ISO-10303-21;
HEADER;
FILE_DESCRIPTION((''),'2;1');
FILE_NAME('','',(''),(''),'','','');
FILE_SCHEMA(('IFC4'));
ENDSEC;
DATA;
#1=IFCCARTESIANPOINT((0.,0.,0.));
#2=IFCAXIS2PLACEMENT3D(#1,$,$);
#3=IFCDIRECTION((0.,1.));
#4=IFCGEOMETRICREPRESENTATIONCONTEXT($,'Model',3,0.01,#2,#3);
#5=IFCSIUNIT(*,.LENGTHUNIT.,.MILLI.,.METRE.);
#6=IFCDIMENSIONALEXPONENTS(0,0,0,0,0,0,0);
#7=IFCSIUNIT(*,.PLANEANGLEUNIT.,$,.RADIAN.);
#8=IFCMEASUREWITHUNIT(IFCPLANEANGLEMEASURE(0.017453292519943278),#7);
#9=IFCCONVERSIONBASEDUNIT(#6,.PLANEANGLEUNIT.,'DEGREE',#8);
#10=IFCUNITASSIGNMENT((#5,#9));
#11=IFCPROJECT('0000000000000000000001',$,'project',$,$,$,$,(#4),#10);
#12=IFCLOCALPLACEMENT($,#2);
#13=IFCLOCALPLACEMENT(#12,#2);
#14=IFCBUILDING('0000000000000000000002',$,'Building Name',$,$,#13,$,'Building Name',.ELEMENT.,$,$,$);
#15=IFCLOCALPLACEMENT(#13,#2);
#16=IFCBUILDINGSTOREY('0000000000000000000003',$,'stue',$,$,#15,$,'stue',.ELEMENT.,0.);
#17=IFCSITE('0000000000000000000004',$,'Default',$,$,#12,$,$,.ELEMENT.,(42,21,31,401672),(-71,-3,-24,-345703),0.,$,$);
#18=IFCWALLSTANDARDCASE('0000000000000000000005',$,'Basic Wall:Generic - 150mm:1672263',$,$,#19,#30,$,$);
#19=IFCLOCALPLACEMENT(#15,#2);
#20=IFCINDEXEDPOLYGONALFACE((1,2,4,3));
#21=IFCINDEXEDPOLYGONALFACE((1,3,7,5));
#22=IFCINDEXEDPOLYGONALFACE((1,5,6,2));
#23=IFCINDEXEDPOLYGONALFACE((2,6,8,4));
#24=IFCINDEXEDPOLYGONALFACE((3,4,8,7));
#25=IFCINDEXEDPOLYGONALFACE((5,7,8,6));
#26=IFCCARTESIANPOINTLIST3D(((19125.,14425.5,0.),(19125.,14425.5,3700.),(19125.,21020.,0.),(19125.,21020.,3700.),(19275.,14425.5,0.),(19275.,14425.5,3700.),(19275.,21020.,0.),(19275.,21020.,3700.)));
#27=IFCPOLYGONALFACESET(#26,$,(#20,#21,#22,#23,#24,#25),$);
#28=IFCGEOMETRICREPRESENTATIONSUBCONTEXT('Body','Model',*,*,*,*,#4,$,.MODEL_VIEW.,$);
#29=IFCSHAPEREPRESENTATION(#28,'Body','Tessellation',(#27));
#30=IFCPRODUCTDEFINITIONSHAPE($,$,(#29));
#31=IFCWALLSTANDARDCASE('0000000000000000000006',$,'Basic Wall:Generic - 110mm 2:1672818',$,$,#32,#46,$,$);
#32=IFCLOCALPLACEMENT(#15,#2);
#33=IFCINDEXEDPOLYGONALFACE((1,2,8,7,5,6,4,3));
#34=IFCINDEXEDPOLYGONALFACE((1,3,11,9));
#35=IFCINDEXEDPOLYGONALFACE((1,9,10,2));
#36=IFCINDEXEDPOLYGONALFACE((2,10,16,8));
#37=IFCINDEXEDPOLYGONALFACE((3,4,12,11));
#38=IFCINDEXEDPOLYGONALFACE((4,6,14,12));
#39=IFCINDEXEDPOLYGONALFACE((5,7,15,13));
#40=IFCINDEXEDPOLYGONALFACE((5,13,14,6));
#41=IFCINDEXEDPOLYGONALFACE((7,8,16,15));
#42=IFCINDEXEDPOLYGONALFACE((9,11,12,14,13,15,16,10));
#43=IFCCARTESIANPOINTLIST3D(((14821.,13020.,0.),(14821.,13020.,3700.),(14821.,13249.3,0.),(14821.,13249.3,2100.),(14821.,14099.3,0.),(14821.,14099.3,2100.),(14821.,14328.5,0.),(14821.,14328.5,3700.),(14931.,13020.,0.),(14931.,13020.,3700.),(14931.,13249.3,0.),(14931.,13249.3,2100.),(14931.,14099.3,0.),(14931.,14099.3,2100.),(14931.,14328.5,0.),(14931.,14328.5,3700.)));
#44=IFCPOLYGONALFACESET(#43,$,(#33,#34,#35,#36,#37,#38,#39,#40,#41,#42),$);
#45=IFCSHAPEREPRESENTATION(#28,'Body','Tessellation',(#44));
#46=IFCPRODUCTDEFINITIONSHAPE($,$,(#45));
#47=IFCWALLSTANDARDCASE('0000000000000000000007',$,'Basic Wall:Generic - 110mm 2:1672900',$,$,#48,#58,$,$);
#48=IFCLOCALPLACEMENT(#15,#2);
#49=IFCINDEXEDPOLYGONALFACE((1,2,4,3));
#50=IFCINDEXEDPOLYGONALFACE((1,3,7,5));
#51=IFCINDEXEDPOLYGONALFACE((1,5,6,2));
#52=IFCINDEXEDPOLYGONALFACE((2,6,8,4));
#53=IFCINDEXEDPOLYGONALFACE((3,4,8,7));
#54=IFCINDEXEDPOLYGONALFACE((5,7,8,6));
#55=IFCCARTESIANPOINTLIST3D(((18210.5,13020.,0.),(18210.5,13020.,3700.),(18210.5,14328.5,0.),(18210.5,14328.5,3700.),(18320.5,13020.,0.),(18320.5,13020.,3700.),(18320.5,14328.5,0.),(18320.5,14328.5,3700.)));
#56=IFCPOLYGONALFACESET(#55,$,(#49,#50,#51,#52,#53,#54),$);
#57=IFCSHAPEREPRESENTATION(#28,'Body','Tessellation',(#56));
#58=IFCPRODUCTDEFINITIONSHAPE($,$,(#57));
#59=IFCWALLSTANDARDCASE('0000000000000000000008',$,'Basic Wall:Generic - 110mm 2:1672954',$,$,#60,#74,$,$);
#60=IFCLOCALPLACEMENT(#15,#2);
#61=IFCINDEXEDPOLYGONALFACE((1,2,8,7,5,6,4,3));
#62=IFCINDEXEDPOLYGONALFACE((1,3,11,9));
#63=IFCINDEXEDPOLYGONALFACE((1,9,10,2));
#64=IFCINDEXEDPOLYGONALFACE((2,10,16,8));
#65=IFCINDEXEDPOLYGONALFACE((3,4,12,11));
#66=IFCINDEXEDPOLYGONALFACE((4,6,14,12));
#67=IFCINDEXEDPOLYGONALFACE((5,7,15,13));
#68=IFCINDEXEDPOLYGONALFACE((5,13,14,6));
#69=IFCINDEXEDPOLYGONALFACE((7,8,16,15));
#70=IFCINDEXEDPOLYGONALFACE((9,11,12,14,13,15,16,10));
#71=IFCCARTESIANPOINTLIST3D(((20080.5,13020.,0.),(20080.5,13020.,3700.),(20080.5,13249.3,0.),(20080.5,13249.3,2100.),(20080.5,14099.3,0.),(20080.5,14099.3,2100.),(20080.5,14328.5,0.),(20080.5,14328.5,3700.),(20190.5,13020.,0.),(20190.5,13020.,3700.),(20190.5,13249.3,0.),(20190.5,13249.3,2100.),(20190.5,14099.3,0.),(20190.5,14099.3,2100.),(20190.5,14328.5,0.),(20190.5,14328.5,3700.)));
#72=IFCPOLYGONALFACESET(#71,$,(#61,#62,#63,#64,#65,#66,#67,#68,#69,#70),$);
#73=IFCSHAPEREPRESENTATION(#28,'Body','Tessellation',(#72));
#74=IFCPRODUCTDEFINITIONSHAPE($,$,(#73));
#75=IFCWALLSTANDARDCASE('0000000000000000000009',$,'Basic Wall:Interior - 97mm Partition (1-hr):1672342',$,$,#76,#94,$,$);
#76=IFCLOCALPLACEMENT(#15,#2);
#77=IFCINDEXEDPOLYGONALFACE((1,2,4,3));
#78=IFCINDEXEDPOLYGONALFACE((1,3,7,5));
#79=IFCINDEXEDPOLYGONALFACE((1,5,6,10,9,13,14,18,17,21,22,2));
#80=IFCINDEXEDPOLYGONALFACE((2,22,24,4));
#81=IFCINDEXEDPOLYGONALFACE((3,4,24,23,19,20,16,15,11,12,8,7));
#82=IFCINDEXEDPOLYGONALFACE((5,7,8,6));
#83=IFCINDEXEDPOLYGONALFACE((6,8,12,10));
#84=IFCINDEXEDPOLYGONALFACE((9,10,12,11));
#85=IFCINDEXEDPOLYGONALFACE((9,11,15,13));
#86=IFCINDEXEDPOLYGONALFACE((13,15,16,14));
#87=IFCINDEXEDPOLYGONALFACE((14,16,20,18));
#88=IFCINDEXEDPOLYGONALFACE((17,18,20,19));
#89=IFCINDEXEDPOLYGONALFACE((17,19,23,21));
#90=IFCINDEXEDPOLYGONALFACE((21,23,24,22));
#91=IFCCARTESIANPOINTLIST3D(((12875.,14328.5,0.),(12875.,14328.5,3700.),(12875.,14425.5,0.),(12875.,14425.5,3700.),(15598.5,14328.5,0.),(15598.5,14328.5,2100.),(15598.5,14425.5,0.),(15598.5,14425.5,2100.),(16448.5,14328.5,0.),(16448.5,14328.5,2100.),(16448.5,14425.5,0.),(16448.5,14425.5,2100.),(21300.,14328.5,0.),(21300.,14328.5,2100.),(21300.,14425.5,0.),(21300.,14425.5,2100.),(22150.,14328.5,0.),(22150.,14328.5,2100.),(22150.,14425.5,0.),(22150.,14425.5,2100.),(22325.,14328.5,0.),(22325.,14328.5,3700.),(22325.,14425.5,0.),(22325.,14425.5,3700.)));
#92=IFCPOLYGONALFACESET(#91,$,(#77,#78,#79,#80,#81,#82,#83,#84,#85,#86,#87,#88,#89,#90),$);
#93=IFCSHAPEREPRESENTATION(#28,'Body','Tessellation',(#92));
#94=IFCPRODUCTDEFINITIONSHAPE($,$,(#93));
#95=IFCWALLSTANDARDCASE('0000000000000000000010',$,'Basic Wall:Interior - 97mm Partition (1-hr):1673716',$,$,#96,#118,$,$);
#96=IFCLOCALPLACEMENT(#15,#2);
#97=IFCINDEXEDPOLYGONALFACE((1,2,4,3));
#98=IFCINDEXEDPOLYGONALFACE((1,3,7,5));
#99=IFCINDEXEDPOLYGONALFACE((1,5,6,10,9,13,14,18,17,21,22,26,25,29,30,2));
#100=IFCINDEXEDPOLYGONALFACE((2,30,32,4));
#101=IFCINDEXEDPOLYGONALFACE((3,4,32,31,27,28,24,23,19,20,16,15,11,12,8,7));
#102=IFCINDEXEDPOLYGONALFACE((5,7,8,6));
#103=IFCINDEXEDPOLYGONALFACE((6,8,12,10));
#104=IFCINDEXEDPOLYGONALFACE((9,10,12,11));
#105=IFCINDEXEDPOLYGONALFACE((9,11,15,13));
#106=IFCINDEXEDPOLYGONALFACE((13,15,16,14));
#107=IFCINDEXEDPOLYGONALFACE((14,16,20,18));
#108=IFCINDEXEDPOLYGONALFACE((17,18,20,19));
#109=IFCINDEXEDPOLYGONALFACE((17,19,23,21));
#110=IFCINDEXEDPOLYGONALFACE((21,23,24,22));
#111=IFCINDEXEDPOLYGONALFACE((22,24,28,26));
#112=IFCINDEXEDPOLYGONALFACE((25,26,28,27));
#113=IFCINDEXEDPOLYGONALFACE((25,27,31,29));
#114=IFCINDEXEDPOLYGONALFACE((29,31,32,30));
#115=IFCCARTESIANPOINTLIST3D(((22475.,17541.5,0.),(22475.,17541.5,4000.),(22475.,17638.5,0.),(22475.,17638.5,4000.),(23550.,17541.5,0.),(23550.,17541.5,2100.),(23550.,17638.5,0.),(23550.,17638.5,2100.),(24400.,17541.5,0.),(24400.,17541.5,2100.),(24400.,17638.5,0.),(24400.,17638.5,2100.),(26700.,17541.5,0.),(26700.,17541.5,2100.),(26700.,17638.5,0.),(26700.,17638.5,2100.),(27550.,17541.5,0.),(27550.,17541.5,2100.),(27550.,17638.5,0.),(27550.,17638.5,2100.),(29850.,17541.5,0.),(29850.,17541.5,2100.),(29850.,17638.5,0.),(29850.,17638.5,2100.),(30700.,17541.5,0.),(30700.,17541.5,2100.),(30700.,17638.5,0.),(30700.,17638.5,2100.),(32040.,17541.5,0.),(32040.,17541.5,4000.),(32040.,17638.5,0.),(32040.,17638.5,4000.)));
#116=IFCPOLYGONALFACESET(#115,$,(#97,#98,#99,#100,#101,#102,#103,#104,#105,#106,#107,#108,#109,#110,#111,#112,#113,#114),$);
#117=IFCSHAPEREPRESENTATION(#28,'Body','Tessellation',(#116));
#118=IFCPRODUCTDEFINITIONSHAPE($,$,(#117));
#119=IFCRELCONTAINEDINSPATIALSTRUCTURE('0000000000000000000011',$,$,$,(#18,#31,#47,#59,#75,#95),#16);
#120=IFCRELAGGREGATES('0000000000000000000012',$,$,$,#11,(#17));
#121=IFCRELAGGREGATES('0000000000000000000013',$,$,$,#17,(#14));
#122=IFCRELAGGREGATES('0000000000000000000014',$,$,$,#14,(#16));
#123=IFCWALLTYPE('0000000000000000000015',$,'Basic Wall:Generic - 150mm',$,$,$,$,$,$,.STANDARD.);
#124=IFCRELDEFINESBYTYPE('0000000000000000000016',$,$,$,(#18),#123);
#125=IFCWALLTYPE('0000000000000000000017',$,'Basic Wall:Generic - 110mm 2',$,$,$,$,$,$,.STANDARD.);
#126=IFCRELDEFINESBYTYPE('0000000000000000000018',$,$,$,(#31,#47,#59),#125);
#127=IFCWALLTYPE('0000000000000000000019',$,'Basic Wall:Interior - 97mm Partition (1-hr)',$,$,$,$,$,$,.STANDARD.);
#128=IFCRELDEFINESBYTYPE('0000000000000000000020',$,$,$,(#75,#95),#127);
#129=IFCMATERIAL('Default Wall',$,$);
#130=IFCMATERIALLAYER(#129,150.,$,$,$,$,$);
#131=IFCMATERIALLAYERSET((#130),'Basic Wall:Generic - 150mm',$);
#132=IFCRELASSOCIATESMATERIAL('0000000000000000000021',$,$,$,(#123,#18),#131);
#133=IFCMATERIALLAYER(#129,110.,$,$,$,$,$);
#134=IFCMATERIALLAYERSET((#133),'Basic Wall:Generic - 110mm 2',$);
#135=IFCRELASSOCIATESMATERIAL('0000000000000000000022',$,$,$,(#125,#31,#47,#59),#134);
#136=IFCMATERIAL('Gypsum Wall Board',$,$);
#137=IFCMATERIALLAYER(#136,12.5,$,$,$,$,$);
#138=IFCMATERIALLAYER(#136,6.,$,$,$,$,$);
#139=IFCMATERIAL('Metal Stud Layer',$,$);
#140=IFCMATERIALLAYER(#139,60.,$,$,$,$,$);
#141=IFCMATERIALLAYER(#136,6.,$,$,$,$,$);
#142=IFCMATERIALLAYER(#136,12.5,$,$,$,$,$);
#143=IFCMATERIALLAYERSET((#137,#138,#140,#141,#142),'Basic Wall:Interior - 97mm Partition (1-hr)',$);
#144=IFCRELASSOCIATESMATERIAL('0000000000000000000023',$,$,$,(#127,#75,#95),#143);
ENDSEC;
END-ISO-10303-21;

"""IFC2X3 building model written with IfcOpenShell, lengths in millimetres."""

from ifc_helpers import new_model, entity, si_unit, converted_unit, direction, frame, frame_2d, origin, place, context, subcontext, project, spatial, polyline, rectangle, extrude, clip, bounded_halfspace, material, layer, layer_set, layer_usage, type_object, element, save


model = new_model("IFC2X3")

# Units and contexts
model_context = context("Model", 3, precision=0.01, world=origin(), true_north=direction((0.0, 1.0)))
body_context = subcontext(model_context, "Body", "Model", "MODEL_VIEW")
ifc_project = project(units=[si_unit("LENGTHUNIT", "METRE", prefix="MILLI"), converted_unit("PLANEANGLEUNIT", "DEGREE", entity("IfcPlaneAngleMeasure", 0.017453292519943278), si_unit("PLANEANGLEUNIT", "RADIAN"), dimensions=[0, 0, 0, 0, 0, 0, 0])], contexts=[model_context])

# Site, building, storey
site_placement = place(None, origin())
site = spatial("IfcSite", under=ifc_project, at=site_placement, Name="Default", CompositionType="ELEMENT", RefLatitude=(42, 21, 31, 401672), RefLongitude=(-71, -3, -24, -345703), RefElevation=0.0)
building_placement = place(site_placement, origin())
building = spatial("IfcBuilding", under=site, at=building_placement, Name="Building Name", LongName="Building Name", CompositionType="ELEMENT")
storey_placement = place(building_placement, origin())
storey = spatial("IfcBuildingStorey", under=building, at=storey_placement, Name="stue", LongName="stue", CompositionType="ELEMENT", Elevation=0.0)

# Wall
ifc_material_1 = material(Name="Default Wall")
ifc_layer_1 = layer(ifc_material_1, 150.0)
ifc_layer_set_1 = layer_set([ifc_layer_1], Name="Basic Wall:Generic - 150mm")
ifc_layer_usage_1 = layer_usage(ifc_layer_set_1, "AXIS2", "NEGATIVE", 75.0)
wall_type_1 = type_object("IfcWallType", Name="Basic Wall:Generic - 150mm", PredefinedType="STANDARD", material=ifc_layer_set_1)
wall_1_placement = place(storey_placement, frame((19200.0, 21020.0, 0.0), z_axis=(0.0, 0.0, 1.0), x_axis=(0.0, -1.0, 0.0)))
element("IfcWallStandardCase", 1, at=wall_1_placement, inside=storey, type_object=wall_type_1, material=ifc_layer_usage_1, Name="Basic Wall:Generic - 150mm:1672263", context=body_context, shape_type="Clipping", body=[
    clip(extrude(rectangle(XDim=6594.5, YDim=150.0, at=frame_2d((3297.2, 0.0), x_axis=(-1.0, 0.0))), origin(), (0.0, 0.0, 1.0), 3700.0), bounded_halfspace(frame((0.0, -75.0, 3700.0), z_axis=(0.0, 0.0, -1.0), x_axis=(1.0, 0.0, 0.0)), True, frame((0.0, -75.0, 3700.0)), polyline([(0.0, 0.0), (1533.0, 0.0), (1647.0, 0.0), (6594.5, 0.0), (6594.5, 150.0), (0.0, 150.0), (0.0, 0.0)]))),
])

# Wall, opening
ifc_layer_2 = layer(ifc_material_1, 110.0)
ifc_layer_set_2 = layer_set([ifc_layer_2], Name="Basic Wall:Generic - 110mm 2")
ifc_layer_usage_2 = layer_usage(ifc_layer_set_2, "AXIS2", "NEGATIVE", 55.0)
wall_type_2 = type_object("IfcWallType", Name="Basic Wall:Generic - 110mm 2", PredefinedType="STANDARD", material=ifc_layer_set_2)
wall_2_placement = place(storey_placement, frame((14876.0, 14328.5, 0.0), z_axis=(0.0, 0.0, 1.0), x_axis=(0.0, -1.0, 0.0)))
wall_2 = element("IfcWallStandardCase", 2, at=wall_2_placement, inside=storey, type_object=wall_type_2, material=ifc_layer_usage_2, Name="Basic Wall:Generic - 110mm 2:1672818", context=body_context, shape_type="Clipping", body=[
    clip(extrude(rectangle(XDim=1308.5, YDim=110.0, at=frame_2d((654.3, 0.0), x_axis=(-1.0, 0.0))), origin(), (0.0, 0.0, 1.0), 3700.0), bounded_halfspace(frame((0.0, -55.0, 3700.0), z_axis=(0.0, 0.0, -1.0), x_axis=(1.0, 0.0, 0.0)), True, frame((0.0, -55.0, 3700.0)), polyline([(0.0, 0.0), (1308.5, 0.0), (1308.5, 110.0), (0.0, 110.0), (0.0, 0.0)]))),
])
opening_1_placement = place(wall_2_placement, frame((1079.3, 55.0, 0.0)))
element("IfcOpeningElement", 3, at=opening_1_placement, cuts=wall_2, ObjectType="Opening", context=body_context, shape_type="SweptSolid", body=[
    extrude(rectangle(XDim=2100.0, YDim=850.0, at=frame_2d((1050.0, 425.0), x_axis=(1.0, 0.0))), frame((0.0, 0.0, 0.0), z_axis=(0.0, -1.0, 0.0), x_axis=(0.0, 0.0, 1.0)), (0.0, 0.0, 1.0), 110.0),
])

# Wall
ifc_layer_usage_3 = layer_usage(ifc_layer_set_2, "AXIS2", "NEGATIVE", 55.0)
wall_3_placement = place(storey_placement, frame((18265.5, 14328.5, 0.0), z_axis=(0.0, 0.0, 1.0), x_axis=(0.0, -1.0, 0.0)))
element("IfcWallStandardCase", 4, at=wall_3_placement, inside=storey, type_object=wall_type_2, material=ifc_layer_usage_3, Name="Basic Wall:Generic - 110mm 2:1672900", context=body_context, shape_type="Clipping", body=[
    clip(extrude(rectangle(XDim=1308.5, YDim=110.0, at=frame_2d((654.3, 0.0), x_axis=(-1.0, 0.0))), origin(), (0.0, 0.0, 1.0), 3700.0), bounded_halfspace(frame((0.0, -55.0, 3700.0), z_axis=(0.0, 0.0, -1.0), x_axis=(1.0, 0.0, 0.0)), True, frame((0.0, -55.0, 3700.0)), polyline([(0.0, 0.0), (1308.5, 0.0), (1308.5, 110.0), (0.0, 110.0), (0.0, 0.0)]))),
])

# Wall, opening
ifc_layer_usage_4 = layer_usage(ifc_layer_set_2, "AXIS2", "NEGATIVE", 55.0)
wall_4_placement = place(storey_placement, frame((20135.5, 14328.5, 0.0), z_axis=(0.0, 0.0, 1.0), x_axis=(0.0, -1.0, 0.0)))
wall_4 = element("IfcWallStandardCase", 5, at=wall_4_placement, inside=storey, type_object=wall_type_2, material=ifc_layer_usage_4, Name="Basic Wall:Generic - 110mm 2:1672954", context=body_context, shape_type="Clipping", body=[
    clip(extrude(rectangle(XDim=1308.5, YDim=110.0, at=frame_2d((654.3, 0.0), x_axis=(1.0, 0.0))), origin(), (0.0, 0.0, 1.0), 3700.0), bounded_halfspace(frame((0.0, -55.0, 3700.0), z_axis=(0.0, 0.0, -1.0), x_axis=(1.0, 0.0, 0.0)), True, frame((0.0, -55.0, 3700.0)), polyline([(0.0, 0.0), (1308.5, 0.0), (1308.5, 110.0), (0.0, 110.0), (0.0, 0.0)]))),
])
opening_2_placement = place(wall_4_placement, frame((1079.3, 55.0, 0.0)))
element("IfcOpeningElement", 6, at=opening_2_placement, cuts=wall_4, ObjectType="Opening", context=body_context, shape_type="SweptSolid", body=[
    extrude(rectangle(XDim=2100.0, YDim=850.0, at=frame_2d((1050.0, 425.0), x_axis=(1.0, 0.0))), frame((0.0, 0.0, 0.0), z_axis=(0.0, -1.0, 0.0), x_axis=(0.0, 0.0, 1.0)), (0.0, 0.0, 1.0), 110.0),
])

# Walls, openings
ifc_material_2 = material(Name="Gypsum Wall Board")
ifc_layer_3 = layer(ifc_material_2, 12.5)
ifc_layer_4 = layer(ifc_material_2, 6.0)
ifc_material_3 = material(Name="Metal Stud Layer")
ifc_layer_5 = layer(ifc_material_3, 60.0)
ifc_layer_6 = layer(ifc_material_2, 6.0)
ifc_layer_7 = layer(ifc_material_2, 12.5)
ifc_layer_set_3 = layer_set([ifc_layer_3, ifc_layer_4, ifc_layer_5, ifc_layer_6, ifc_layer_7], Name="Basic Wall:Interior - 97mm Partition (1-hr)")
ifc_layer_usage_5 = layer_usage(ifc_layer_set_3, "AXIS2", "NEGATIVE", 48.5)
wall_type_3 = type_object("IfcWallType", Name="Basic Wall:Interior - 97mm Partition (1-hr)", PredefinedType="STANDARD", material=ifc_layer_set_3)
wall_5_placement = place(storey_placement, frame((22325.0, 14377.0, 0.0), z_axis=(0.0, 0.0, 1.0), x_axis=(-1.0, 0.0, 0.0)))
wall_5 = element("IfcWallStandardCase", 7, at=wall_5_placement, inside=storey, type_object=wall_type_3, material=ifc_layer_usage_5, Name="Basic Wall:Interior - 97mm Partition (1-hr):1672342", context=body_context, shape_type="Clipping", body=[
    clip(extrude(rectangle(XDim=9450.0, YDim=97.0, at=frame_2d((4725.0, 0.0), x_axis=(1.0, 0.0))), origin(), (0.0, 0.0, 1.0), 3700.0), bounded_halfspace(frame((0.0, -48.5, 3700.0), z_axis=(0.0, 0.0, -1.0), x_axis=(0.0, 1.0, 0.0)), True, frame((0.0, -48.5, 3700.0)), polyline([(0.0, 0.0), (3050.0, 0.0), (3200.0, 0.0), (9450.0, 0.0), (9450.0, 97.0), (7504.0, 97.0), (7394.0, 97.0), (4114.5, 97.0), (4004.5, 97.0), (2244.5, 97.0), (2134.5, 97.0), (0.0, 97.0), (0.0, 0.0)]))),
])
opening_3_placement = place(wall_5_placement, frame((1025.0, 48.5, 0.0)))
element("IfcOpeningElement", 8, at=opening_3_placement, cuts=wall_5, ObjectType="Opening", context=body_context, shape_type="SweptSolid", body=[
    extrude(rectangle(XDim=2100.0, YDim=850.0, at=frame_2d((1050.0, 425.0), x_axis=(1.0, 0.0))), frame((0.0, 0.0, 0.0), z_axis=(0.0, -1.0, 0.0), x_axis=(0.0, 0.0, 1.0)), (0.0, 0.0, 1.0), 97.0),
])
opening_4_placement = place(wall_5_placement, frame((6726.5, 48.5, 0.0)))
element("IfcOpeningElement", 9, at=opening_4_placement, cuts=wall_5, ObjectType="Opening", context=body_context, shape_type="SweptSolid", body=[
    extrude(rectangle(XDim=2100.0, YDim=850.0, at=frame_2d((1050.0, 425.0), x_axis=(1.0, 0.0))), frame((0.0, 0.0, 0.0), z_axis=(0.0, -1.0, 0.0), x_axis=(0.0, 0.0, 1.0)), (0.0, 0.0, 1.0), 97.0),
])
ifc_layer_usage_6 = layer_usage(ifc_layer_set_3, "AXIS2", "NEGATIVE", 48.5)
wall_6_placement = place(storey_placement, frame((22475.0, 17590.0, 0.0)))
wall_6 = element("IfcWallStandardCase", 10, at=wall_6_placement, inside=storey, type_object=wall_type_3, material=ifc_layer_usage_6, Name="Basic Wall:Interior - 97mm Partition (1-hr):1673716", context=body_context, shape_type="SweptSolid", body=[
    extrude(rectangle(XDim=9565.0, YDim=97.0, at=frame_2d((4782.5, 0.0), x_axis=(-1.0, 0.0))), origin(), (0.0, 0.0, 1.0), 4000.0),
])
opening_5_placement = place(wall_6_placement, frame((1075.0, -48.5, 0.0)))
element("IfcOpeningElement", 11, at=opening_5_placement, cuts=wall_6, ObjectType="Opening", context=body_context, shape_type="SweptSolid", body=[
    extrude(rectangle(XDim=2100.0, YDim=850.0, at=frame_2d((1050.0, 425.0), x_axis=(1.0, 0.0))), frame((0.0, 0.0, 0.0), z_axis=(0.0, 1.0, 0.0), x_axis=(0.0, 0.0, 1.0)), (0.0, 0.0, 1.0), 97.0),
])
opening_6_placement = place(wall_6_placement, frame((4225.0, -48.5, 0.0)))
element("IfcOpeningElement", 12, at=opening_6_placement, cuts=wall_6, ObjectType="Opening", context=body_context, shape_type="SweptSolid", body=[
    extrude(rectangle(XDim=2100.0, YDim=850.0, at=frame_2d((1050.0, 425.0), x_axis=(1.0, 0.0))), frame((0.0, 0.0, 0.0), z_axis=(0.0, 1.0, 0.0), x_axis=(0.0, 0.0, 1.0)), (0.0, 0.0, 1.0), 97.0),
])
opening_7_placement = place(wall_6_placement, frame((7375.0, -48.5, 0.0)))
element("IfcOpeningElement", 13, at=opening_7_placement, cuts=wall_6, ObjectType="Opening", context=body_context, shape_type="SweptSolid", body=[
    extrude(rectangle(XDim=2100.0, YDim=850.0, at=frame_2d((1050.0, 425.0), x_axis=(1.0, 0.0))), frame((0.0, 0.0, 0.0), z_axis=(0.0, 1.0, 0.0), x_axis=(0.0, 0.0, 1.0)), (0.0, 0.0, 1.0), 97.0),
])

save(model, "model.ifc")
